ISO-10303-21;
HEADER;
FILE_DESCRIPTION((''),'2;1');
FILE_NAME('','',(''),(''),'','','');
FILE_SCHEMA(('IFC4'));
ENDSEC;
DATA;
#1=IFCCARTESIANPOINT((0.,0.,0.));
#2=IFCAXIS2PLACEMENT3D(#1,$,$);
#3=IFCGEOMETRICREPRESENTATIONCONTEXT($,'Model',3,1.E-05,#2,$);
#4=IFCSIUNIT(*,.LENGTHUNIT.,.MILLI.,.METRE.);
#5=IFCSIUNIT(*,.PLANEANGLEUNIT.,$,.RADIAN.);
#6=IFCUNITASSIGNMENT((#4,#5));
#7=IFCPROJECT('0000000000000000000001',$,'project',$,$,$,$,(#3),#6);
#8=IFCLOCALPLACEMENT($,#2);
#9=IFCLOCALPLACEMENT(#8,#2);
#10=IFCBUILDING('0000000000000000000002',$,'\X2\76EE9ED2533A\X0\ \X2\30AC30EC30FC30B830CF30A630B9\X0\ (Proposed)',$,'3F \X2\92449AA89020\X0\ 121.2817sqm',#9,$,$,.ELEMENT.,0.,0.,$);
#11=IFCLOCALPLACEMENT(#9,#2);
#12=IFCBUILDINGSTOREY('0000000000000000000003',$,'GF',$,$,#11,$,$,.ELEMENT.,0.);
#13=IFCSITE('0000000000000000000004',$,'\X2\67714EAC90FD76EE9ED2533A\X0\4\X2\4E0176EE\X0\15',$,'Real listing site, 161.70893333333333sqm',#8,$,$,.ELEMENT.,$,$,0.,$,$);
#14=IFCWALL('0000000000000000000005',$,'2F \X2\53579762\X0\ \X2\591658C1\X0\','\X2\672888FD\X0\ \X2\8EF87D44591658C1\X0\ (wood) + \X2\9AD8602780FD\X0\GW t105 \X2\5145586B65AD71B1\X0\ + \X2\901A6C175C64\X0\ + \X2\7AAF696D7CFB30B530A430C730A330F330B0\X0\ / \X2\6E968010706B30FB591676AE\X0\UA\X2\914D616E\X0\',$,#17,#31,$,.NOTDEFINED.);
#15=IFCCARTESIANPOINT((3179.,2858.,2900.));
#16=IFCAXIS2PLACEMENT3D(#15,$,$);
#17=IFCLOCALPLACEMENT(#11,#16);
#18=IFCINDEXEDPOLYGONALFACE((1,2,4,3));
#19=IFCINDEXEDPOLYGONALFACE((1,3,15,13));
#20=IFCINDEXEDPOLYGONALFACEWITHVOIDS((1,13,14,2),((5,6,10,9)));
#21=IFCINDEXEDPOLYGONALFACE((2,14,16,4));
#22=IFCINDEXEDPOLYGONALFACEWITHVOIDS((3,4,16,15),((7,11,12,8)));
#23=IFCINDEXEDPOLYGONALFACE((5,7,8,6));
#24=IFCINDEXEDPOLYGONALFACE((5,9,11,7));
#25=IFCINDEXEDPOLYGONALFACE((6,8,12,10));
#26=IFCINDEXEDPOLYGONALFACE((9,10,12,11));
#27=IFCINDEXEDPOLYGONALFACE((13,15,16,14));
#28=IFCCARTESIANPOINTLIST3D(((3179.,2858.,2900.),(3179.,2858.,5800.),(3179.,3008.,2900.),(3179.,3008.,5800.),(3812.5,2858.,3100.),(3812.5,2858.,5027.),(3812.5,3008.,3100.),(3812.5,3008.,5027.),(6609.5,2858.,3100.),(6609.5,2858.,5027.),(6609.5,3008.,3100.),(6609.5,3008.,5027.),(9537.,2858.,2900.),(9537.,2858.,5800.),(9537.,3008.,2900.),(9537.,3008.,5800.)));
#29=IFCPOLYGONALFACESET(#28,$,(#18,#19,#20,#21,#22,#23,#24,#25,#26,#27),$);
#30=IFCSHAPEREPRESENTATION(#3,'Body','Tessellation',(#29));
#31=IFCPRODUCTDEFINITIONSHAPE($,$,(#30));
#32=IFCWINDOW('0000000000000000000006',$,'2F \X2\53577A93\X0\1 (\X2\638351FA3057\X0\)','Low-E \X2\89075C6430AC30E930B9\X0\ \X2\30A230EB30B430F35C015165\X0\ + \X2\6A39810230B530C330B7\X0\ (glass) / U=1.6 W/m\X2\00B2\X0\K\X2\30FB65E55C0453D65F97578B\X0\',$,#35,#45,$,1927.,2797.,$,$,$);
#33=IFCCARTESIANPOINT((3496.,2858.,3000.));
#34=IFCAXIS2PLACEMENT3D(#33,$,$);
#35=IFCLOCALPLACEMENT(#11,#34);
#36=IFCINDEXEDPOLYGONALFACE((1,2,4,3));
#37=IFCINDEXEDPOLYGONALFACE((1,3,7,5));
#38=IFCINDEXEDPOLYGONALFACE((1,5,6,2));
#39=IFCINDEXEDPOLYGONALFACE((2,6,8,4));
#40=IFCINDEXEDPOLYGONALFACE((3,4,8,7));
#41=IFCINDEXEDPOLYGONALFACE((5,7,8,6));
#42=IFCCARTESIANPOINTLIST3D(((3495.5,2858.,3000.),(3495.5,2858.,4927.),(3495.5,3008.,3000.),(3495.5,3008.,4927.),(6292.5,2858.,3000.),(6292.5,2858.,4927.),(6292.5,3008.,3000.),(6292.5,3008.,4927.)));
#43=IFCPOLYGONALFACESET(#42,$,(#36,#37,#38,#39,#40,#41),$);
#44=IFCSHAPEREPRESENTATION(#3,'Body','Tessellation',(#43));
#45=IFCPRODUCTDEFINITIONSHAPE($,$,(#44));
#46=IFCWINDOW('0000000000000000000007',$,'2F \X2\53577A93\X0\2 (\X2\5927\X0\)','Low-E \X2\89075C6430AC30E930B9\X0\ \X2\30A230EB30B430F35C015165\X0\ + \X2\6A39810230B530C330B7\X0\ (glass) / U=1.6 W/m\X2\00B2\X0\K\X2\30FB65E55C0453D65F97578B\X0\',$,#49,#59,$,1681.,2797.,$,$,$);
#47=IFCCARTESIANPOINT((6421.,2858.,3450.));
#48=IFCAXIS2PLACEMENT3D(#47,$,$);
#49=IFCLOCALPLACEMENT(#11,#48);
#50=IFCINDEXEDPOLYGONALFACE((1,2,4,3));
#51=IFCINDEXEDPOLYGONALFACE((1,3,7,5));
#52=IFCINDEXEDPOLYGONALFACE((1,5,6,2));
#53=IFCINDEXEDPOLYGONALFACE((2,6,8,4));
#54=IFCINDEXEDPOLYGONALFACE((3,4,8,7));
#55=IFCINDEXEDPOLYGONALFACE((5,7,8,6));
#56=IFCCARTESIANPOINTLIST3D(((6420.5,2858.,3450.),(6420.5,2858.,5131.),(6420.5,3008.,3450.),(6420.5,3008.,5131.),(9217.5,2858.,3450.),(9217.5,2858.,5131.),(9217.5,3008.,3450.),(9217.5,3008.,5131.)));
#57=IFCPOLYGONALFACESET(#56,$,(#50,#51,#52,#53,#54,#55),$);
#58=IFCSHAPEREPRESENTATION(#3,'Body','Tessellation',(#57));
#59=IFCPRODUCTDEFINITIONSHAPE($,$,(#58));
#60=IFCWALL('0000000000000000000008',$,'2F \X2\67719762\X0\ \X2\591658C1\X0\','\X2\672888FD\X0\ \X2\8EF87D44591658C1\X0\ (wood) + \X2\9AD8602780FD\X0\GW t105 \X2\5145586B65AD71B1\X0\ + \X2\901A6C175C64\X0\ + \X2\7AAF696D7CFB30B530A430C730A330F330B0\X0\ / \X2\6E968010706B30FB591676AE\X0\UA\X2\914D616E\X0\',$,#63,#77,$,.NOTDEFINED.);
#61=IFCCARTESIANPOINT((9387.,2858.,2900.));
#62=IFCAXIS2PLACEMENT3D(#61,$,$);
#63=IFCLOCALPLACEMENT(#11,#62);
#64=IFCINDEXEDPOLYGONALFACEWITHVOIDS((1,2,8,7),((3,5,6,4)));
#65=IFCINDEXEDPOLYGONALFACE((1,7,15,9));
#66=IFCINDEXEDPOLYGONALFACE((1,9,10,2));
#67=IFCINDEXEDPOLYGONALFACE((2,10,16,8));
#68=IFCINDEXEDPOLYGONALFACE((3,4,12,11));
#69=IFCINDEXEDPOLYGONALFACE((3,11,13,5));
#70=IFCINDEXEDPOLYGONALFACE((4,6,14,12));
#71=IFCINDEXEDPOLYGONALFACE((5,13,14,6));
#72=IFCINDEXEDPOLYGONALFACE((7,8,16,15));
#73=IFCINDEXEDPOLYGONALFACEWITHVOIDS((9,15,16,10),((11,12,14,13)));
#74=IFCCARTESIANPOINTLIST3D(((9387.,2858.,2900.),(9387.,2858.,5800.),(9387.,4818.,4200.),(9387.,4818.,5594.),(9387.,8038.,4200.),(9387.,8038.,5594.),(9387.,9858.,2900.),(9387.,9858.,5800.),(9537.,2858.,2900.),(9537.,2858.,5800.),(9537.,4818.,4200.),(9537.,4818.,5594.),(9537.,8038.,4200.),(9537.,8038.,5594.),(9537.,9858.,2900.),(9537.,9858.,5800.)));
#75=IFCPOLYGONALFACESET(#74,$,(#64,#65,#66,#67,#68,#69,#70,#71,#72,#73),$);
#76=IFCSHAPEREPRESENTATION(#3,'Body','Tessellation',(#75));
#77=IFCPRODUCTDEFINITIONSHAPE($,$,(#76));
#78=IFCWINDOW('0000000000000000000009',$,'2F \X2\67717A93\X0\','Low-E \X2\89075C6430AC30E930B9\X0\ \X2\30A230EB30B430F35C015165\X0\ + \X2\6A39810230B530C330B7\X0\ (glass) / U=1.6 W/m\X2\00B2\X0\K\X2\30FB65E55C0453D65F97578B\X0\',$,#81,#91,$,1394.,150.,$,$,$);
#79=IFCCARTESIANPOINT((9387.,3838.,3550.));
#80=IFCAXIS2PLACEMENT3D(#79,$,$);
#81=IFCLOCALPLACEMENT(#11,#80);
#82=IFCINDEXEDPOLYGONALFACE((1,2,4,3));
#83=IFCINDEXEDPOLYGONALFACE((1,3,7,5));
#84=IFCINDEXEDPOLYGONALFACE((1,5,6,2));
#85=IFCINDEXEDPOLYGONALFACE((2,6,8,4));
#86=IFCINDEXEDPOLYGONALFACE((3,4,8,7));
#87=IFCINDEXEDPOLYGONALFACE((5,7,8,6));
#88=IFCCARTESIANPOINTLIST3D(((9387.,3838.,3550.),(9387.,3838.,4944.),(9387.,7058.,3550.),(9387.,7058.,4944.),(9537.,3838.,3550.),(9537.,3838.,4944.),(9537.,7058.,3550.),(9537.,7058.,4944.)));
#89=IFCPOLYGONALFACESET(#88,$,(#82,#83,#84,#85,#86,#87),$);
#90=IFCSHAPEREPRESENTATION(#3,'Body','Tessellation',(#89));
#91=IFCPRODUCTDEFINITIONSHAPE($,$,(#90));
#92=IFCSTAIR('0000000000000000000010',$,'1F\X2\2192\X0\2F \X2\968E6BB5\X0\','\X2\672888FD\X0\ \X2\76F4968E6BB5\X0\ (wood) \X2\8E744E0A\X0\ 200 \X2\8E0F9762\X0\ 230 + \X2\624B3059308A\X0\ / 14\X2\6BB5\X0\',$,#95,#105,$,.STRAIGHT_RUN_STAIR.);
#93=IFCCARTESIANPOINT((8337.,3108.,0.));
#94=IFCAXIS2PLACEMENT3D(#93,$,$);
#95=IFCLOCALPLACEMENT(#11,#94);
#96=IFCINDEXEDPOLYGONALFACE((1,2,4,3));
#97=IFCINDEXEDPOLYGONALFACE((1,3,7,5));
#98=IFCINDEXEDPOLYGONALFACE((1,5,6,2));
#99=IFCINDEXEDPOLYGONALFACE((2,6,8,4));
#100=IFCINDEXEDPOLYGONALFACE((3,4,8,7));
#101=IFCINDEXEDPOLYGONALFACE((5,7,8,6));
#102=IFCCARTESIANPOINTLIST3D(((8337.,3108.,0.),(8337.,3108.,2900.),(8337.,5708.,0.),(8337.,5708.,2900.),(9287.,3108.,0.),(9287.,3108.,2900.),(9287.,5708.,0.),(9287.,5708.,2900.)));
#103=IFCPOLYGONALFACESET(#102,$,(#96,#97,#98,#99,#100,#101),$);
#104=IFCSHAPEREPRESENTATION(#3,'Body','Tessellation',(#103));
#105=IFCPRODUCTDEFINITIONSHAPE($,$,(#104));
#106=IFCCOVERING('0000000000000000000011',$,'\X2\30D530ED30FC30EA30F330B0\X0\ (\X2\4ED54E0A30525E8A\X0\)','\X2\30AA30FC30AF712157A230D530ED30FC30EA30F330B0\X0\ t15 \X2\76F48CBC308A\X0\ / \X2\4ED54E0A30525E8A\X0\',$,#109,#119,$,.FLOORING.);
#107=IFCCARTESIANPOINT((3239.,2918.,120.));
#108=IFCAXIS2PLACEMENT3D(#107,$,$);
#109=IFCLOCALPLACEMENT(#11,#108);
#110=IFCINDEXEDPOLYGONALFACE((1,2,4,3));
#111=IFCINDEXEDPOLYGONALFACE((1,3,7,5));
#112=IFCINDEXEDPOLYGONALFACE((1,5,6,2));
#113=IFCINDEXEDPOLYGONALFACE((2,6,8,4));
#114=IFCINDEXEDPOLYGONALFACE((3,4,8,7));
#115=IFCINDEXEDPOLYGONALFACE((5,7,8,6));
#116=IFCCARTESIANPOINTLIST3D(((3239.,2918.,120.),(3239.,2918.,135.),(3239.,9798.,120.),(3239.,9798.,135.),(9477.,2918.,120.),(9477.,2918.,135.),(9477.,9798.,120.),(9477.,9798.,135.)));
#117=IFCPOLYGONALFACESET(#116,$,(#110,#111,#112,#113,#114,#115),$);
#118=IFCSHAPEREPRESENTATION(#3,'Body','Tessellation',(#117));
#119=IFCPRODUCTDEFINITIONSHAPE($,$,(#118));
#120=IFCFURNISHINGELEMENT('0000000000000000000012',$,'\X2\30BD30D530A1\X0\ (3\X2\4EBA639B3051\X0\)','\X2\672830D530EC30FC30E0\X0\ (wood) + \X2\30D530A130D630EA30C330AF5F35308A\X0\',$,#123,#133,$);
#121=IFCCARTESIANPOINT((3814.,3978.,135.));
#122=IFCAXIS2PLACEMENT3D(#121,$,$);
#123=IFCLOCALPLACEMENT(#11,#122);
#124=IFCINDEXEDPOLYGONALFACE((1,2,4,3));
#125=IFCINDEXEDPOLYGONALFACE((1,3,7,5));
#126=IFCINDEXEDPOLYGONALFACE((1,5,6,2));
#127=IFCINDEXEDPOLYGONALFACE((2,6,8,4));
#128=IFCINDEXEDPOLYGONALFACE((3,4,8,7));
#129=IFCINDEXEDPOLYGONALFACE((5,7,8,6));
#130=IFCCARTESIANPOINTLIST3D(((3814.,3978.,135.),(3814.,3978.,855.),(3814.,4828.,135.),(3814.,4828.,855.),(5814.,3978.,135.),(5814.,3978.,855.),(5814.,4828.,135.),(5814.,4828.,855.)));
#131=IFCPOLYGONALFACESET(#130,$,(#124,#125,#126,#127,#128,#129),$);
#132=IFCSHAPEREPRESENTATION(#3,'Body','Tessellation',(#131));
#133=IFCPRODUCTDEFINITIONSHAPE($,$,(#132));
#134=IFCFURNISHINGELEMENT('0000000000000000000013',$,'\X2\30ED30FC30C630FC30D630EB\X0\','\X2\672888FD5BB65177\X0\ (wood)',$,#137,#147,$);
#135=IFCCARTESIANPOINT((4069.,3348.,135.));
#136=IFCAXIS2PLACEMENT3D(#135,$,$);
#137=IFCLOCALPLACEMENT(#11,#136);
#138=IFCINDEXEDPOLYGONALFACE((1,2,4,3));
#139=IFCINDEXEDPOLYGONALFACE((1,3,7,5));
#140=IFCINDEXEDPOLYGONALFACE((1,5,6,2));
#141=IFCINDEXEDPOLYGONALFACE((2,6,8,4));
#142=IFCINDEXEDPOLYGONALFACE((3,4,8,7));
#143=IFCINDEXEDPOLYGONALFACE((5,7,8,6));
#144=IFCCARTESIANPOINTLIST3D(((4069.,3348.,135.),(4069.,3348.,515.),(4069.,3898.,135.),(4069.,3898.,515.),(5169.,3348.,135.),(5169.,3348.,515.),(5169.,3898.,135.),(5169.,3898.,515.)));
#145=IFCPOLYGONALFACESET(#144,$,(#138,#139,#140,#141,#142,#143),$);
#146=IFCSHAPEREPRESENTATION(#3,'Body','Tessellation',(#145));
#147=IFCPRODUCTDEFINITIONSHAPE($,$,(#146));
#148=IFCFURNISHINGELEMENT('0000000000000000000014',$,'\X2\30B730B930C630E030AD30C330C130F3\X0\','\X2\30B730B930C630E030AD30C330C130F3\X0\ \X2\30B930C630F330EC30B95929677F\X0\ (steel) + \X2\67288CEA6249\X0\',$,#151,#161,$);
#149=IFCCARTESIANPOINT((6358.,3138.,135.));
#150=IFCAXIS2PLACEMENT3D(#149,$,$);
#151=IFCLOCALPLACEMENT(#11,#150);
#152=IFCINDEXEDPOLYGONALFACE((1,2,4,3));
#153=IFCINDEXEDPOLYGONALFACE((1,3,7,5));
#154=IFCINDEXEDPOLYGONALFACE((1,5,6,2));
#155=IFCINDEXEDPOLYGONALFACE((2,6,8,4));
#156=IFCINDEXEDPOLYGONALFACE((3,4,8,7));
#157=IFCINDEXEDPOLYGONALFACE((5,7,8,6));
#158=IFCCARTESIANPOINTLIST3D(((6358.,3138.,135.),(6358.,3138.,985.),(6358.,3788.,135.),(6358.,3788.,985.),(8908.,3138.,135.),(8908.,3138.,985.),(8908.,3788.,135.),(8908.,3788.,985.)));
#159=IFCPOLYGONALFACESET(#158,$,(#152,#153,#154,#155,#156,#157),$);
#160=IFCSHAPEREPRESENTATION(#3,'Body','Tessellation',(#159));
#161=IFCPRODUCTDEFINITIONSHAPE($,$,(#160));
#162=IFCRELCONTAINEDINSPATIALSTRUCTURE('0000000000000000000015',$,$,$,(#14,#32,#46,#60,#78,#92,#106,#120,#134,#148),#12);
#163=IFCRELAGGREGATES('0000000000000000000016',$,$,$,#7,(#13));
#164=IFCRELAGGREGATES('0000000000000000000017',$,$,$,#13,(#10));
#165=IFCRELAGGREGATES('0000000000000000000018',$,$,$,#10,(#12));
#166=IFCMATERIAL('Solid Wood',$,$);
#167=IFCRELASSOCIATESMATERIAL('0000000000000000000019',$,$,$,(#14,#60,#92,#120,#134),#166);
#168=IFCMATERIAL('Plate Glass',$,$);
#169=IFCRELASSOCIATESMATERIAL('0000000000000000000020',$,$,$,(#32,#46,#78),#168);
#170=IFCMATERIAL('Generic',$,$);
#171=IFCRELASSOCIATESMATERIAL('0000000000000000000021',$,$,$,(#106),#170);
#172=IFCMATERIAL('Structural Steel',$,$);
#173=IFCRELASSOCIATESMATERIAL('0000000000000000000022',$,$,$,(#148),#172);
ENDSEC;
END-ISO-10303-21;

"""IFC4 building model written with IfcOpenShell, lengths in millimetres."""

from ifc_helpers import new_model, si_unit, frame, frame_2d, origin, place, context, project, spatial, rectangle, extrude, material, element, fill, save


model = new_model("IFC4")

# Units and contexts
model_context = context("Model", 3, precision=1e-05, world=origin())
ifc_project = project(units=[si_unit("LENGTHUNIT", "METRE", prefix="MILLI"), si_unit("PLANEANGLEUNIT", "RADIAN")], contexts=[model_context])

# Site, building, storey
site_placement = place(None, origin())
site = spatial("IfcSite", under=ifc_project, at=site_placement, Name="東京都目黒区4丁目15", ObjectType="Real listing site, 161.70893333333333sqm", CompositionType="ELEMENT", RefElevation=0.0)
building_placement = place(site_placement, origin())
building = spatial("IfcBuilding", under=site, at=building_placement, Name="目黒区 ガレージハウス (Proposed)", ObjectType="3F 鉄骨造 121.2817sqm", CompositionType="ELEMENT", ElevationOfRefHeight=0.0, ElevationOfTerrain=0.0)
storey_placement = place(building_placement, origin())
storey = spatial("IfcBuildingStorey", under=building, at=storey_placement, Name="GF", CompositionType="ELEMENT", Elevation=0.0)

# Shared definitions
ifc_material_1 = material(Name="Solid Wood")

# Shared definitions
ifc_material_2 = material(Name="Plate Glass")

# Wall, openings, windows
wall_1_placement = place(storey_placement, frame((3179.0, 2858.0, 2900.0)))
wall_1 = element("IfcWall", 1, at=wall_1_placement, inside=storey, material=ifc_material_1, Name="2F 南面 外壁", Description="木製 軸組外壁 (wood) + 高性能GW t105 充填断熱 + 通気層 + 窯業系サイディング / 準耐火・外皮UA配慮", PredefinedType="NOTDEFINED", context=model_context, shape_type="SweptSolid", body=[
    extrude(rectangle(XDim=6358.0, YDim=150.0, at=frame_2d((3179.0, 75.0))), frame((3179.0, 2858.0, 2900.0)), (0.0, 0.0, 1.0), 2900.0),
])
opening_1_placement = place(storey_placement, frame((3496.0, 2858.0, 3000.0)))
opening_1 = element("IfcOpeningElement", 2, at=opening_1_placement, cuts=wall_1, PredefinedType="NOTDEFINED", context=model_context, shape_type="SweptSolid", body=[
    extrude(rectangle(XDim=2797.0, YDim=150.0, at=frame_2d((1398.0, 75.0))), frame((3496.0, 2858.0, 3000.0)), (0.0, 0.0, 1.0), 1927.0),
])
opening_2_placement = place(storey_placement, frame((6421.0, 2858.0, 3450.0)))
opening_2 = element("IfcOpeningElement", 3, at=opening_2_placement, cuts=wall_1, PredefinedType="NOTDEFINED", context=model_context, shape_type="SweptSolid", body=[
    extrude(rectangle(XDim=2797.0, YDim=150.0, at=frame_2d((1398.0, 75.0))), frame((6421.0, 2858.0, 3450.0)), (0.0, 0.0, 1.0), 1681.0),
])
window_1_placement = place(storey_placement, frame((3496.0, 2858.0, 3000.0)))
window_1 = element("IfcWindow", 4, at=window_1_placement, inside=storey, material=ifc_material_2, Name="2F 南窓1 (掃出し)", Description="Low-E 複層ガラス アルゴン封入 + 樹脂サッシ (glass) / U=1.6 W/m²K・日射取得型", OverallHeight=1927.0, OverallWidth=2797.0, context=model_context, shape_type="SweptSolid", body=[
    extrude(rectangle(XDim=2797.0, YDim=150.0, at=frame_2d((1398.0, 75.0))), frame((3496.0, 2858.0, 3000.0)), (0.0, 0.0, 1.0), 1927.0),
])
fill(opening_1, window_1)
window_2_placement = place(storey_placement, frame((6421.0, 2858.0, 3450.0)))
window_2 = element("IfcWindow", 5, at=window_2_placement, inside=storey, material=ifc_material_2, Name="2F 南窓2 (大)", Description="Low-E 複層ガラス アルゴン封入 + 樹脂サッシ (glass) / U=1.6 W/m²K・日射取得型", OverallHeight=1681.0, OverallWidth=2797.0, context=model_context, shape_type="SweptSolid", body=[
    extrude(rectangle(XDim=2797.0, YDim=150.0, at=frame_2d((1398.0, 75.0))), frame((6421.0, 2858.0, 3450.0)), (0.0, 0.0, 1.0), 1681.0),
])
fill(opening_2, window_2)

# Wall, opening, window
wall_2_placement = place(storey_placement, frame((9387.0, 2858.0, 2900.0)))
wall_2 = element("IfcWall", 6, at=wall_2_placement, inside=storey, material=ifc_material_1, Name="2F 東面 外壁", Description="木製 軸組外壁 (wood) + 高性能GW t105 充填断熱 + 通気層 + 窯業系サイディング / 準耐火・外皮UA配慮", PredefinedType="NOTDEFINED", context=model_context, shape_type="SweptSolid", body=[
    extrude(rectangle(XDim=150.0, YDim=7000.0, at=frame_2d((75.0, 3500.0))), frame((9387.0, 2858.0, 2900.0)), (0.0, 0.0, 1.0), 2900.0),
])
opening_3_placement = place(storey_placement, frame((9387.0, 3838.0, 3550.0)))
opening_3 = element("IfcOpeningElement", 7, at=opening_3_placement, cuts=wall_2, PredefinedType="NOTDEFINED", context=model_context, shape_type="SweptSolid", body=[
    extrude(rectangle(XDim=150.0, YDim=3220.0, at=frame_2d((75.0, 1610.0))), frame((9387.0, 3838.0, 3550.0)), (0.0, 0.0, 1.0), 1394.0),
])
window_3_placement = place(storey_placement, frame((9387.0, 3838.0, 3550.0)))
window_3 = element("IfcWindow", 8, at=window_3_placement, inside=storey, material=ifc_material_2, Name="2F 東窓", Description="Low-E 複層ガラス アルゴン封入 + 樹脂サッシ (glass) / U=1.6 W/m²K・日射取得型", OverallHeight=1394.0, OverallWidth=150.0, context=model_context, shape_type="SweptSolid", body=[
    extrude(rectangle(XDim=150.0, YDim=3220.0, at=frame_2d((75.0, 1610.0))), frame((9387.0, 3838.0, 3550.0)), (0.0, 0.0, 1.0), 1394.0),
])
fill(opening_3, window_3)

# Stair
stair_placement = place(storey_placement, frame((8337.0, 3108.0, 0.0)))
element("IfcStair", 9, at=stair_placement, inside=storey, material=ifc_material_1, Name="1F→2F 階段", Description="木製 直階段 (wood) 蹴上 200 踏面 230 + 手すり / 14段", PredefinedType="STRAIGHT_RUN_STAIR", context=model_context, shape_type="SweptSolid", body=[
    extrude(rectangle(XDim=950.0, YDim=2600.0, at=frame_2d((475.0, 1300.0))), frame((8337.0, 3108.0, 0.0)), (0.0, 0.0, 1.0), 2900.0),
])

# Covering
ifc_material_3 = material(Name="Generic")
covering_placement = place(storey_placement, frame((3239.0, 2918.0, 120.0)))
element("IfcCovering", 10, at=covering_placement, inside=storey, material=ifc_material_3, Name="フローリング (仕上げ床)", Description="オーク無垢フローリング t15 直貼り / 仕上げ床", PredefinedType="FLOORING", context=model_context, shape_type="SweptSolid", body=[
    extrude(rectangle(XDim=6238.0, YDim=6880.0, at=frame_2d((3119.0, 3440.0))), frame((3239.0, 2918.0, 120.0)), (0.0, 0.0, 1.0), 15.0),
])

# Furnishing elements
furnishing_1_placement = place(storey_placement, frame((3814.0, 3978.0, 135.0)))
element("IfcFurnishingElement", 11, at=furnishing_1_placement, inside=storey, material=ifc_material_1, Name="ソファ (3人掛け)", Description="木フレーム (wood) + ファブリック張り", context=model_context, shape_type="SweptSolid", body=[
    extrude(rectangle(XDim=2000.0, YDim=850.0, at=frame_2d((1000.0, 425.0))), frame((3814.0, 3978.0, 135.0)), (0.0, 0.0, 1.0), 720.0),
])
furnishing_2_placement = place(storey_placement, frame((4069.0, 3348.0, 135.0)))
element("IfcFurnishingElement", 12, at=furnishing_2_placement, inside=storey, material=ifc_material_1, Name="ローテーブル", Description="木製家具 (wood)", context=model_context, shape_type="SweptSolid", body=[
    extrude(rectangle(XDim=1100.0, YDim=550.0, at=frame_2d((550.0, 275.0))), frame((4069.0, 3348.0, 135.0)), (0.0, 0.0, 1.0), 380.0),
])
ifc_material_4 = material(Name="Structural Steel")
furnishing_3_placement = place(storey_placement, frame((6358.0, 3138.0, 135.0)))
element("IfcFurnishingElement", 13, at=furnishing_3_placement, inside=storey, material=ifc_material_4, Name="システムキッチン", Description="システムキッチン ステンレス天板 (steel) + 木質扉", context=model_context, shape_type="SweptSolid", body=[
    extrude(rectangle(XDim=2550.0, YDim=650.0, at=frame_2d((1275.0, 325.0))), frame((6358.0, 3138.0, 135.0)), (0.0, 0.0, 1.0), 850.0),
])

save(model, "model.ifc")
